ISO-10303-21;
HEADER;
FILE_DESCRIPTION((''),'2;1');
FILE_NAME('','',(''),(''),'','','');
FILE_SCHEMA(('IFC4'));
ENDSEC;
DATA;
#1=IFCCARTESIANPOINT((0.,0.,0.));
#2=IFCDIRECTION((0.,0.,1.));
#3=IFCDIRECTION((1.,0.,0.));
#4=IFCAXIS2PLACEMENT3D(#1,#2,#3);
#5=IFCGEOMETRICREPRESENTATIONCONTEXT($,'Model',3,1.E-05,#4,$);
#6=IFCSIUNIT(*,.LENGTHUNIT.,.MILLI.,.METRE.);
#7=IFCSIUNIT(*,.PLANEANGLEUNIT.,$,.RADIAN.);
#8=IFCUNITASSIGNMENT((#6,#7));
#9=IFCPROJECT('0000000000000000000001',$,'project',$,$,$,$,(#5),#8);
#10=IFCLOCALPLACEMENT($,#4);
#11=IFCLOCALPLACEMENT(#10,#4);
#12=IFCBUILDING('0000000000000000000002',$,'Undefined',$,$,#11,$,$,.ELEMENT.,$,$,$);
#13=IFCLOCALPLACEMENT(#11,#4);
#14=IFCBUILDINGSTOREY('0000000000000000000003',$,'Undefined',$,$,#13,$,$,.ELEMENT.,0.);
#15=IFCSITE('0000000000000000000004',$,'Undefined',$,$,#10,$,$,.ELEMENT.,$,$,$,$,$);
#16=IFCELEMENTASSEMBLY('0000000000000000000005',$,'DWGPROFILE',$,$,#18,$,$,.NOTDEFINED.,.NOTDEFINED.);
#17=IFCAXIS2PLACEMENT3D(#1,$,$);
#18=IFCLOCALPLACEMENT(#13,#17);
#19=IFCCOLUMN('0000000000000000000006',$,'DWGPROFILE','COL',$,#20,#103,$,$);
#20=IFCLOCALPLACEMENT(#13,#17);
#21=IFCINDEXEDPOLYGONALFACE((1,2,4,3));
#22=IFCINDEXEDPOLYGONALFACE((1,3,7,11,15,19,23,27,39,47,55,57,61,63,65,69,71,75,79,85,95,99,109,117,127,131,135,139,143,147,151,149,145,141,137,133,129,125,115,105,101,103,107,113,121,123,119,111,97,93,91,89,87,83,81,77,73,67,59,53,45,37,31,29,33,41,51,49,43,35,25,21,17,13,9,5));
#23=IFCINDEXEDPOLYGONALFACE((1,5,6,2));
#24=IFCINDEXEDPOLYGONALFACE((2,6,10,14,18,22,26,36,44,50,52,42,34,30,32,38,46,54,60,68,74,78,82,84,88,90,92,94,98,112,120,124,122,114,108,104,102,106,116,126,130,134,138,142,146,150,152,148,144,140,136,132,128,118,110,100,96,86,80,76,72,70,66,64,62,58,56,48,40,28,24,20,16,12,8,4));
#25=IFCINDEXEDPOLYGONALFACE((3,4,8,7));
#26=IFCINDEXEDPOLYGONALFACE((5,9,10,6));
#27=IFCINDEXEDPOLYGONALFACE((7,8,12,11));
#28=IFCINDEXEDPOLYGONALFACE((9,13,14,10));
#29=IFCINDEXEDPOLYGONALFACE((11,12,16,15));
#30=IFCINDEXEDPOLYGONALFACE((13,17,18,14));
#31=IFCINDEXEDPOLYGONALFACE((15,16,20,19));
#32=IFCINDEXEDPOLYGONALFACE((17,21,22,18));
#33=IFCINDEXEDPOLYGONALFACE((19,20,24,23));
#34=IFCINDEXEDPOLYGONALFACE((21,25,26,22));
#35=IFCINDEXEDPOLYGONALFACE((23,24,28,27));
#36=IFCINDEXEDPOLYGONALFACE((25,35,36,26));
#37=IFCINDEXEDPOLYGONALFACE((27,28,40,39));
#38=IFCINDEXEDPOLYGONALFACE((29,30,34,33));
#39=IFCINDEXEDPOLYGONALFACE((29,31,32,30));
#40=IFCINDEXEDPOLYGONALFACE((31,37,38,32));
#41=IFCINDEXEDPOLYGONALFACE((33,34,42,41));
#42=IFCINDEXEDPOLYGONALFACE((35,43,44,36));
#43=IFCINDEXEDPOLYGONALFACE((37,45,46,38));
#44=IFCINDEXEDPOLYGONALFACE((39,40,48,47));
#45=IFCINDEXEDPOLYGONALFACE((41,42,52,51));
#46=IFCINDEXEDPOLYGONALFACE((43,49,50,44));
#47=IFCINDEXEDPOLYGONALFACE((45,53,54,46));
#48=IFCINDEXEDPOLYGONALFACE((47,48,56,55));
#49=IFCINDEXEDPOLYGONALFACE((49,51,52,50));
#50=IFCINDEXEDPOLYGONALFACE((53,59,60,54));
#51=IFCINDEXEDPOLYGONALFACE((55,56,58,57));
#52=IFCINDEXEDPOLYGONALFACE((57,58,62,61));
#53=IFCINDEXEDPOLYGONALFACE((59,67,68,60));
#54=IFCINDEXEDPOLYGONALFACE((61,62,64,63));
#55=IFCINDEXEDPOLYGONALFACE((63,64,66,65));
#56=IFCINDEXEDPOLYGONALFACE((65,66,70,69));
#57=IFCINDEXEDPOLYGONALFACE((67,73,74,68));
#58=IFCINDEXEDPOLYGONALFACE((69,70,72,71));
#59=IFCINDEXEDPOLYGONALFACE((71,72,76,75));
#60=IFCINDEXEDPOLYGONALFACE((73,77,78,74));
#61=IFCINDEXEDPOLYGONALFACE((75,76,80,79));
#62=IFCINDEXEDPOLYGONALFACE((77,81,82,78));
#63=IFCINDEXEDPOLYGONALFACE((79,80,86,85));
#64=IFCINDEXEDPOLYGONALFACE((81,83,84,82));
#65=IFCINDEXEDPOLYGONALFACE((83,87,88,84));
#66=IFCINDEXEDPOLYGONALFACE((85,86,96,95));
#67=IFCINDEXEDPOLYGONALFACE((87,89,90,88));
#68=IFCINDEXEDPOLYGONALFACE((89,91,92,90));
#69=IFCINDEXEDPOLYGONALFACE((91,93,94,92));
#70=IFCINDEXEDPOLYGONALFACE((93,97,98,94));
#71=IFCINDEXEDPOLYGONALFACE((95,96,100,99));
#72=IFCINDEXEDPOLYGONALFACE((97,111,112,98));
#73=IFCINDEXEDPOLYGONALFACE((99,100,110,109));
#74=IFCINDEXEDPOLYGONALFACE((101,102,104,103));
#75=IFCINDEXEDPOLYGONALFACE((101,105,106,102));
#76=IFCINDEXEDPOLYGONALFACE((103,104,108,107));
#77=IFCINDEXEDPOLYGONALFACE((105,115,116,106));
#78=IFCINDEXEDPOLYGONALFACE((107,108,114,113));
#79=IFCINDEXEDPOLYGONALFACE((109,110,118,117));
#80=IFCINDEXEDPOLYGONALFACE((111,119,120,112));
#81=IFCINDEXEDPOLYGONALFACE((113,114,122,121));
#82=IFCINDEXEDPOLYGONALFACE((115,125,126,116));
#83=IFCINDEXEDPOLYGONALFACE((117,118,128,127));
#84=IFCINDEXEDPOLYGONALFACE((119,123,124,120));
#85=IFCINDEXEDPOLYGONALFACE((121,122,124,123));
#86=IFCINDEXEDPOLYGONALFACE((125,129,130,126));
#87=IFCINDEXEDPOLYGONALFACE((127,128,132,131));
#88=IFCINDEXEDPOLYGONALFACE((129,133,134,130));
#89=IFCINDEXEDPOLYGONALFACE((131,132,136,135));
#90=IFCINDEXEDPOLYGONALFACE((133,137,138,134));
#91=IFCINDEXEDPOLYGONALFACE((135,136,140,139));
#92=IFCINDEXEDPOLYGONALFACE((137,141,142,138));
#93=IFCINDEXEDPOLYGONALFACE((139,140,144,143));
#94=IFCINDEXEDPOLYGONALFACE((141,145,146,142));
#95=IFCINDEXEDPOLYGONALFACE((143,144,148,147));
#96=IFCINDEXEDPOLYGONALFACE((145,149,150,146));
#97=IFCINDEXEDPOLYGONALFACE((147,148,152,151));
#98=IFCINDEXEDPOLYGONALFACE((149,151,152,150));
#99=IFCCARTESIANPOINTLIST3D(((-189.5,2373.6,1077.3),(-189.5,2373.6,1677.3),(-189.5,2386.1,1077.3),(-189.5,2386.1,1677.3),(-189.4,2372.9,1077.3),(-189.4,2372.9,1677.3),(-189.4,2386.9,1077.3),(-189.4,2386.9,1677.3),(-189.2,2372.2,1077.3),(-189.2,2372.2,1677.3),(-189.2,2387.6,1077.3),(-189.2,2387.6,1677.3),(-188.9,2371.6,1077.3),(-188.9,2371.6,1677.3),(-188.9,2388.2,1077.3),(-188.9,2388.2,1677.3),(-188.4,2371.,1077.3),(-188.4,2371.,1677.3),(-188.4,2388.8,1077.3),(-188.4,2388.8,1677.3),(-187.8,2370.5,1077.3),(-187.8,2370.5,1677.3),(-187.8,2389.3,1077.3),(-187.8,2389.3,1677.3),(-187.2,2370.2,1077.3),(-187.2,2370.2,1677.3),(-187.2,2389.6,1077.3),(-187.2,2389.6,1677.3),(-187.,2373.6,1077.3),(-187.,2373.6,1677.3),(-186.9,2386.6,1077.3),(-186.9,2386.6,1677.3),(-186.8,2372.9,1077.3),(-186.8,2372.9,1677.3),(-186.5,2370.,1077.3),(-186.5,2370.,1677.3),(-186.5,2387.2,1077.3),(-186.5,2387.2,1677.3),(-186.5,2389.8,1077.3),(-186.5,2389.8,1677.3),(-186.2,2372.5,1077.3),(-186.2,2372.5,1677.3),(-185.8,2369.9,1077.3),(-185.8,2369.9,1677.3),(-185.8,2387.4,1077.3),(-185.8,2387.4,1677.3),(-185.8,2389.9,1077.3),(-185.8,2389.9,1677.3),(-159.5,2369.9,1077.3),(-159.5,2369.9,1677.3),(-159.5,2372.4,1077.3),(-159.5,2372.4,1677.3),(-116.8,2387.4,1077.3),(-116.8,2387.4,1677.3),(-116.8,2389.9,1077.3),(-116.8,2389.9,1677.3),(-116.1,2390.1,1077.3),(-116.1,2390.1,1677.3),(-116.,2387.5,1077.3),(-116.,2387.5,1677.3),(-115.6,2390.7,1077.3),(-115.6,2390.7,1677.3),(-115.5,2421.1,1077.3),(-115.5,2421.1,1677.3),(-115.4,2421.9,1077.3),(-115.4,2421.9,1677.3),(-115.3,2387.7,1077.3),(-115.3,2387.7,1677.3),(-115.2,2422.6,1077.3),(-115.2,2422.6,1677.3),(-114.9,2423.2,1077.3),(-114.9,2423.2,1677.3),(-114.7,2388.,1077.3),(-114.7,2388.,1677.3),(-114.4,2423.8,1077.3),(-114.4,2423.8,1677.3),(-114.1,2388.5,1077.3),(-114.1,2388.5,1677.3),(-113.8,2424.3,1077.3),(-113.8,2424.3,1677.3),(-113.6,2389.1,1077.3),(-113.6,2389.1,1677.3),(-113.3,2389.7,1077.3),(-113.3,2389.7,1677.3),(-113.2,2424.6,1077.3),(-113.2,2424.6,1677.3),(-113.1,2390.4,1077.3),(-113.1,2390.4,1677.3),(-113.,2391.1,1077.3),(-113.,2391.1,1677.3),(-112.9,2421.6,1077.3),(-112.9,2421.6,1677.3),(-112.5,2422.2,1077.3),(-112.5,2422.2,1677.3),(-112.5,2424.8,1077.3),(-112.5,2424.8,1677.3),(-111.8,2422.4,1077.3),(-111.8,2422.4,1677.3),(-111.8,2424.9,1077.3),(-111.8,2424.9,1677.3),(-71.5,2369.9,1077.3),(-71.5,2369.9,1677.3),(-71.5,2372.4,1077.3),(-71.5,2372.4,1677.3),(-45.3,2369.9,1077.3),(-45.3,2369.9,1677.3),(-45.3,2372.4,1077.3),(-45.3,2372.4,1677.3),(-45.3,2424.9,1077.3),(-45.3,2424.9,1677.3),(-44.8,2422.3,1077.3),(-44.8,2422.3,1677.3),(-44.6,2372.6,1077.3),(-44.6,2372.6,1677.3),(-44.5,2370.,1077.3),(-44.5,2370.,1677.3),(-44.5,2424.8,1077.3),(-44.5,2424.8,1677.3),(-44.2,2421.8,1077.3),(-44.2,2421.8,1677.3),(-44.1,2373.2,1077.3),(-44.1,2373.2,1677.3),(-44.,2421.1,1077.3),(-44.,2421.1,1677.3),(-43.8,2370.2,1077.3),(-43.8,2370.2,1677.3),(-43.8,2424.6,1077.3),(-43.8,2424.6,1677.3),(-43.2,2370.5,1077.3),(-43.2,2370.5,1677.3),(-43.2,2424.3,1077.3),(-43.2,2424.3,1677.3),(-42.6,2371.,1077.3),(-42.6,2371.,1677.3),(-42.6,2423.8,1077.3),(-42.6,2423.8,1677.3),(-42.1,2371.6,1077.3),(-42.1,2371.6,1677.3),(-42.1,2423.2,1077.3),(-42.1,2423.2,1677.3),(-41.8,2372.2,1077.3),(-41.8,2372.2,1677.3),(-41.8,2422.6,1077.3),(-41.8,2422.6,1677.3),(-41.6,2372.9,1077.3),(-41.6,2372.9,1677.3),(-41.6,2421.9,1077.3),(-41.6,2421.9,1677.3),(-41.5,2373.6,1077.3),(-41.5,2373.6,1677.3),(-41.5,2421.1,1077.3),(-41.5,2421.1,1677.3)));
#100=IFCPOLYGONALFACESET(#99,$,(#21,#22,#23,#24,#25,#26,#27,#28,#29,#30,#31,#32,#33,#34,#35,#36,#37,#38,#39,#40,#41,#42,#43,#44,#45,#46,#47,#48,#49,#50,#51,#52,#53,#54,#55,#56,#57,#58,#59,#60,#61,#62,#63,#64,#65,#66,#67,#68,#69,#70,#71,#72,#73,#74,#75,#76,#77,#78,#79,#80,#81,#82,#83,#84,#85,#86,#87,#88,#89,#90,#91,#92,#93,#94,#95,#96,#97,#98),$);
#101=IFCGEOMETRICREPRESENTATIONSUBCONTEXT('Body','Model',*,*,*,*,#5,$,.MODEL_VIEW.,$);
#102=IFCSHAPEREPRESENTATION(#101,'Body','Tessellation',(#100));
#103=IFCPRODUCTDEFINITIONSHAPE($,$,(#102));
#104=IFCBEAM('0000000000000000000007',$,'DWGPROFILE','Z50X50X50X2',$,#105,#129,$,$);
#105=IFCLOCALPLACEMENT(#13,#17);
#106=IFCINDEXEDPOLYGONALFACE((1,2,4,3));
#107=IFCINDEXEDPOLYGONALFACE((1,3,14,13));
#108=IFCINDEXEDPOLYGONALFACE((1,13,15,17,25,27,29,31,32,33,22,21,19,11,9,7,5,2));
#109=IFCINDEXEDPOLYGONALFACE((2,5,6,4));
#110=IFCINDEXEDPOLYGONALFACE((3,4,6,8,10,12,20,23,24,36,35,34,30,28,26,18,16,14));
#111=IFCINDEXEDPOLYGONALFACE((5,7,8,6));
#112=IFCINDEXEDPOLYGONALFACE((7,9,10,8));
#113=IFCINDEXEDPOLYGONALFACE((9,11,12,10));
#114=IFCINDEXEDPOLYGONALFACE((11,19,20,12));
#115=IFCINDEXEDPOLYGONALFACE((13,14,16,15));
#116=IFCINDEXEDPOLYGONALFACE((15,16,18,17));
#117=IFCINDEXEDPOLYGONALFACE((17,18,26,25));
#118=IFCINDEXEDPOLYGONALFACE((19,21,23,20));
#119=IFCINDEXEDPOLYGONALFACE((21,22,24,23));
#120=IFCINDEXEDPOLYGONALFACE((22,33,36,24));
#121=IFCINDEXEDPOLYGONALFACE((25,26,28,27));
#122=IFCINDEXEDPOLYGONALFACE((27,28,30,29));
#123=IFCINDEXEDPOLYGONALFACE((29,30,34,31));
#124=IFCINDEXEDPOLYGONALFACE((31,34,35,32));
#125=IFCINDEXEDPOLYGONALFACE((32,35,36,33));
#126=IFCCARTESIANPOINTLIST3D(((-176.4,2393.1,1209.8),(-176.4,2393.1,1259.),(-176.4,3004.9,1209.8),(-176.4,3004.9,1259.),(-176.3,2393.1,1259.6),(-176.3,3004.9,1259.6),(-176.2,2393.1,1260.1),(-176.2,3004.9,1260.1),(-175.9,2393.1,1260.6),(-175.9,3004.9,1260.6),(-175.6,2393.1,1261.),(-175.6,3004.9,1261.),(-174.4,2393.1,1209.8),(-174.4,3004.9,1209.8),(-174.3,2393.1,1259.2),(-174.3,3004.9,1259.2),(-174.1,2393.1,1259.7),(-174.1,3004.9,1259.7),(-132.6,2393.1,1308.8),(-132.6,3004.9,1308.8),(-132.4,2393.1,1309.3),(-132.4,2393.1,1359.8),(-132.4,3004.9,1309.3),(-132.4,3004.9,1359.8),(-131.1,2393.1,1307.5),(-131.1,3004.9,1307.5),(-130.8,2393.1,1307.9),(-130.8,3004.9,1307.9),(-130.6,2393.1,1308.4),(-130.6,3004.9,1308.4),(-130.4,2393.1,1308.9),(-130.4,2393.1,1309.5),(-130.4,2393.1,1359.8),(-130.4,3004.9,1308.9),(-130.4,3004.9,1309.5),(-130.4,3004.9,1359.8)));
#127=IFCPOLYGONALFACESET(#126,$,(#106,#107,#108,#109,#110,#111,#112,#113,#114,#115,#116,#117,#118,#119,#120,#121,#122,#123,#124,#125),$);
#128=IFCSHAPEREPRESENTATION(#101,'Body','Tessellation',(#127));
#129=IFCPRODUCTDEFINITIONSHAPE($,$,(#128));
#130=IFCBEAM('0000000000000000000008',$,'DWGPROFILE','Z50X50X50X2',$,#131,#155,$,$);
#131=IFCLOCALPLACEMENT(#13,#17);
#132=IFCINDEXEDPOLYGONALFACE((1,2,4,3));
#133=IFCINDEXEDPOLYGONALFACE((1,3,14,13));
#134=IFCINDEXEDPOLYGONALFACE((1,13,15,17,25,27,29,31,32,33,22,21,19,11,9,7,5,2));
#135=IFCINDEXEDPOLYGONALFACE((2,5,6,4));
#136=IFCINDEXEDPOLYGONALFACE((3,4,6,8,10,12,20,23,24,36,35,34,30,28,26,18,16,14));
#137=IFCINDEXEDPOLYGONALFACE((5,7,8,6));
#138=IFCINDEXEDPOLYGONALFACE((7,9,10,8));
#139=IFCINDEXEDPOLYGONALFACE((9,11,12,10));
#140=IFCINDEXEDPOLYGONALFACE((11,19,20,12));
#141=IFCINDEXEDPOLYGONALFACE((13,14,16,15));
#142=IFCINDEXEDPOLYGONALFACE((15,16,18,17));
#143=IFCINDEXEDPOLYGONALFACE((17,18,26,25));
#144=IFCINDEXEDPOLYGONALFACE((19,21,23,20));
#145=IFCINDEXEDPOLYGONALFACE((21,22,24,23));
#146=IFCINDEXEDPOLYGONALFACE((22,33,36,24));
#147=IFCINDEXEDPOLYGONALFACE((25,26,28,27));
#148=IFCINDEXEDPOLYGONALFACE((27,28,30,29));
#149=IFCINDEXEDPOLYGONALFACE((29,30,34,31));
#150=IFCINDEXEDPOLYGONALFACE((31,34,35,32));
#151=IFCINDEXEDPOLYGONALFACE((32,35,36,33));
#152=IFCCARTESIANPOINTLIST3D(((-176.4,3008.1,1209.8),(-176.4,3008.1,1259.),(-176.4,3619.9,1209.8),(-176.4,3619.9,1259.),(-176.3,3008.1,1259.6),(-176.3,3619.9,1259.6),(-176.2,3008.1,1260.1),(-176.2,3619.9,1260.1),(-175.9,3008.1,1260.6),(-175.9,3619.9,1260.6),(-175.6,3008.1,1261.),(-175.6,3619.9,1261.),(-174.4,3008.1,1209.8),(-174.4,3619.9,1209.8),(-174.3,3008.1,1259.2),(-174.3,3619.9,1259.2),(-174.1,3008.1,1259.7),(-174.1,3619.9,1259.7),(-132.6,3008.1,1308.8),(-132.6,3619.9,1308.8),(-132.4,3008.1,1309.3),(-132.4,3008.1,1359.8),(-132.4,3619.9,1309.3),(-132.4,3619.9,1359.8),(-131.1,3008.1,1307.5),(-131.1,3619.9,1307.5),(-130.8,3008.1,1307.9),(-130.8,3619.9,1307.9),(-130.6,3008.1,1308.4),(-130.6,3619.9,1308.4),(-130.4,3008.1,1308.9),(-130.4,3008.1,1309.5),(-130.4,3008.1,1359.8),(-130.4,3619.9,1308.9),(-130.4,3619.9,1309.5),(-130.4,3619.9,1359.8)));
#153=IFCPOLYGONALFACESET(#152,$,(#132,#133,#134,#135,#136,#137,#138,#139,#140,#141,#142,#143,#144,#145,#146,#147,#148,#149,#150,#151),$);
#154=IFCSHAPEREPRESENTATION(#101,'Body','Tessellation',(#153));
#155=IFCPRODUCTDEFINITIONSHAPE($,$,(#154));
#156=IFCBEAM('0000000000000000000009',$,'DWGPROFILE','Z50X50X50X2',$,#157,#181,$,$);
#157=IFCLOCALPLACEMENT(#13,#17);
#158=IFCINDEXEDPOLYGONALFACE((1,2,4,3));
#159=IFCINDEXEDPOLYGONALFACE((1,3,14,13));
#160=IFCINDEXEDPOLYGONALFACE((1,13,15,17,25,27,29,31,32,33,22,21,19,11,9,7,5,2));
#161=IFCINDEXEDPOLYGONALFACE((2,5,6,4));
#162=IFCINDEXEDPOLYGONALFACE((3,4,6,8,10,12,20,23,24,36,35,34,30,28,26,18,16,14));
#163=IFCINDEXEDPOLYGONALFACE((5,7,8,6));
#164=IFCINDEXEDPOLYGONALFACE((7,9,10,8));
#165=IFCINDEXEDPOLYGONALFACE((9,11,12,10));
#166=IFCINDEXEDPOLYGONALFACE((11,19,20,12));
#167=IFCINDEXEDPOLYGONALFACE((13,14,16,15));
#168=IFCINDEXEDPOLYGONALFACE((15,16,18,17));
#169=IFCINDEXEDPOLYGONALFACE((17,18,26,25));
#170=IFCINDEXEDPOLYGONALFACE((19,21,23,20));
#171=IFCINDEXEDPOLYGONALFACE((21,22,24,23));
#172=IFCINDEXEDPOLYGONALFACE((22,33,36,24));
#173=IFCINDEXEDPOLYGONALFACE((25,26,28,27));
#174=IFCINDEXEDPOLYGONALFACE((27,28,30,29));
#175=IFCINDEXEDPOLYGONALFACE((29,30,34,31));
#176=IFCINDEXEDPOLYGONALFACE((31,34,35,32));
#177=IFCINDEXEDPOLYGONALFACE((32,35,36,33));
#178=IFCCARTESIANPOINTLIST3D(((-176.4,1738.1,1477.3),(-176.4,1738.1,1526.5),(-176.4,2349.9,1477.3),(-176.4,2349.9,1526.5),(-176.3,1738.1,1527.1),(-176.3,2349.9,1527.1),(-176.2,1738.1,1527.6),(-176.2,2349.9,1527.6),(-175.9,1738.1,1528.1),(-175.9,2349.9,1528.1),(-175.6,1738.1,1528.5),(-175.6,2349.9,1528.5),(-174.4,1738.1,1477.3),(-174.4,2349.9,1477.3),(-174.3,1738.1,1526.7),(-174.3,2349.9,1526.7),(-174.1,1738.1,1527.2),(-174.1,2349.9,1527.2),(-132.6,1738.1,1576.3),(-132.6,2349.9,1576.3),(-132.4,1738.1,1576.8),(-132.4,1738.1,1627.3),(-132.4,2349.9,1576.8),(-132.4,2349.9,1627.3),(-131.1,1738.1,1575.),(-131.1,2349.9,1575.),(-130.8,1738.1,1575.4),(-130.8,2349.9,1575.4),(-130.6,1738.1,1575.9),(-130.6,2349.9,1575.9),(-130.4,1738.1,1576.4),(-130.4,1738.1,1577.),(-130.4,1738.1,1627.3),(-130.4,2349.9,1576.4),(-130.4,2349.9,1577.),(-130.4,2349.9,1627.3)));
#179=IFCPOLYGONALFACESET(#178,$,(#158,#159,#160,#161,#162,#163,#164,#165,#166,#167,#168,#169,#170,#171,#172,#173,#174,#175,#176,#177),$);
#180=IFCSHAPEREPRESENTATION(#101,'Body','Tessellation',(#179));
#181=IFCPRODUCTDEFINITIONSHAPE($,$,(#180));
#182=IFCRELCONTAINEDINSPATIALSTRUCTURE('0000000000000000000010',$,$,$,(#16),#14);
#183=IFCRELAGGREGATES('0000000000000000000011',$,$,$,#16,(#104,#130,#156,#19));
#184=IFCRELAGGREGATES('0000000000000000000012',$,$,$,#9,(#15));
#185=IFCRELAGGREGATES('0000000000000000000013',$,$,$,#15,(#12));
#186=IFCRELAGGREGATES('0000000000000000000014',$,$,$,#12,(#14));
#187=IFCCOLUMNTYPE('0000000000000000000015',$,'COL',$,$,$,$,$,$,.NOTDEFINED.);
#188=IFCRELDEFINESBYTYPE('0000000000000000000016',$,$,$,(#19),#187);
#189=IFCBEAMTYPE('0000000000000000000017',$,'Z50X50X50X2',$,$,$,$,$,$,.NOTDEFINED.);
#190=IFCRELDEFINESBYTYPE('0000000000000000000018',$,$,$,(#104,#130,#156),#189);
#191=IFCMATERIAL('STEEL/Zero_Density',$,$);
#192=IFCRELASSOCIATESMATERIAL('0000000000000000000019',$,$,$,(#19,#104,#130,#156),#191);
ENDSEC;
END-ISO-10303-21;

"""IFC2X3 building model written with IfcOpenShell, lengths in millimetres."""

from ifc_helpers import new_model, si_unit, frame, origin_with_axes, place, context, subcontext, project, spatial, polyline, outline, extrude, material, type_object, element, aggregate, save


model = new_model("IFC2X3")

# Units and contexts
model_context = context("Model", 3, precision=1e-05, world=origin_with_axes())
body_context = subcontext(model_context, "Body", "Model", "MODEL_VIEW")
ifc_project = project(units=[si_unit("LENGTHUNIT", "METRE", prefix="MILLI"), si_unit("PLANEANGLEUNIT", "RADIAN")], contexts=[model_context])

# Site, building, storey
site_placement = place(None, origin_with_axes())
site = spatial("IfcSite", under=ifc_project, at=site_placement, Name="Undefined", CompositionType="ELEMENT")
building_placement = place(site_placement, origin_with_axes())
building = spatial("IfcBuilding", under=site, at=building_placement, Name="Undefined", CompositionType="ELEMENT")
storey_placement = place(building_placement, origin_with_axes())
storey = spatial("IfcBuildingStorey", under=building, at=storey_placement, Name="Undefined", CompositionType="ELEMENT", Elevation=0.0)

# Element assembly, column, beams
assembly_1_placement = place(storey_placement, origin_with_axes())
assembly_1 = element("IfcElementAssembly", 1, at=assembly_1_placement, inside=storey, Name="DWGPROFILE", AssemblyPlace="NOTDEFINED", PredefinedType="NOTDEFINED")
ifc_material_1 = material(Name="STEEL/Zero_Density")
column_type = type_object("IfcColumnType", Name="COL", PredefinedType="NOTDEFINED")
column_placement = place(assembly_1_placement, frame((-115.5, 2397.4, 1077.3), z_axis=(0.0, 0.0, 1.0), x_axis=(1.0, 0.0, 0.0)))
column = element("IfcColumn", 2, at=column_placement, type_object=column_type, material=ifc_material_1, Name="DWGPROFILE", Description="COL", context=body_context, shape_type="SweptSolid", body=[
    extrude(outline(polyline([(27.5, 70.2), (27.5, 3.8), (27.4, 3.0), (27.2, 2.3), (26.9, 1.7), (26.4, 1.1), (25.8, 0.6), (25.2, 0.3), (24.5, 0.1), (23.8, 0.0), (-6.7, -0.1), (-7.3, -0.6), (-7.5, -1.2), (-7.5, -70.2), (-7.6, -71.0), (-7.8, -71.7), (-8.1, -72.3), (-8.6, -72.9), (-9.2, -73.4), (-9.8, -73.7), (-10.5, -73.9), (-11.2, -74.0), (-23.8, -74.0), (-24.5, -73.9), (-25.2, -73.7), (-25.8, -73.4), (-26.4, -72.9), (-26.9, -72.3), (-27.2, -71.7), (-27.4, -71.0), (-27.5, -70.2), (-27.5, -44.0), (-25.0, -44.0), (-24.9, -70.7), (-24.4, -71.3), (-23.8, -71.5), (-10.8, -71.4), (-10.2, -70.9), (-10.0, -70.2), (-10.0, -1.2), (-9.9, -0.5), (-9.7, 0.2), (-9.4, 0.8), (-8.9, 1.4), (-8.3, 1.9), (-7.7, 2.2), (-7.0, 2.4), (-6.2, 2.5), (24.2, 2.6), (24.8, 3.1), (25.0, 3.8), (24.9, 70.7), (24.4, 71.3), (23.8, 71.5), (-24.2, 71.4), (-24.8, 70.9), (-25.0, 70.2), (-25.0, 44.0), (-27.5, 44.0), (-27.5, 70.2), (-27.4, 71.0), (-27.2, 71.7), (-26.9, 72.3), (-26.4, 72.9), (-25.8, 73.4), (-25.2, 73.7), (-24.5, 73.9), (-23.8, 74.0), (23.8, 74.0), (24.5, 73.9), (25.2, 73.7), (25.8, 73.4), (26.4, 72.9), (26.9, 72.3), (27.2, 71.7), (27.4, 71.0), (27.5, 70.2)])), frame((0.0, 0.0, 600.0), z_axis=(0.0, 0.000001, -1.0), x_axis=(0.0, 1.0, 0.0)), (0.0, 0.0, 1.0), 600.0),
])
beam_type_1 = type_object("IfcBeamType", Name="Z50X50X50X2", PredefinedType="NOTDEFINED")
beam_1_placement = place(assembly_1_placement, frame((-153.4, 3004.9, 1284.8), z_axis=(0.0, 0.0, 1.0), x_axis=(0.0, -1.0, 0.0)))
beam_1 = element("IfcBeam", 3, at=beam_1_placement, type_object=beam_type_1, material=ifc_material_1, Name="DWGPROFILE", Description="Z50X50X50X2", context=body_context, shape_type="SweptSolid", body=[
    extrude(outline(polyline([(-22.9, 24.1), (-23.0, 24.7), (-23.0, 75.0), (-21.0, 75.0), (-21.0, 24.5), (-20.7, 24.0), (22.2, -23.8), (22.6, -24.2), (22.8, -24.7), (22.9, -25.2), (23.0, -25.8), (23.0, -75.0), (21.0, -75.0), (21.0, -25.6), (20.7, -25.1), (-22.2, 22.6), (-22.6, 23.1), (-22.8, 23.6), (-22.9, 24.1)])), frame((611.8, 0.0, 0.0), z_axis=(-1.0, 0.0, 0.0), x_axis=(0.0, -1.0, 0.0)), (0.0, 0.0, 1.0), 611.8),
])
beam_2_placement = place(assembly_1_placement, frame((-153.4, 3619.9, 1284.8), z_axis=(0.0, 0.0, 1.0), x_axis=(0.0, -1.0, 0.0)))
beam_2 = element("IfcBeam", 4, at=beam_2_placement, type_object=beam_type_1, material=ifc_material_1, Name="DWGPROFILE", Description="Z50X50X50X2", context=body_context, shape_type="SweptSolid", body=[
    extrude(outline(polyline([(-22.9, 24.1), (-23.0, 24.7), (-23.0, 75.0), (-21.0, 75.0), (-21.0, 24.5), (-20.7, 24.0), (22.2, -23.8), (22.6, -24.2), (22.8, -24.7), (22.9, -25.2), (23.0, -25.8), (23.0, -75.0), (21.0, -75.0), (21.0, -25.6), (20.7, -25.1), (-22.2, 22.6), (-22.6, 23.1), (-22.8, 23.6), (-22.9, 24.1)])), frame((611.8, 0.0, 0.0), z_axis=(-1.0, 0.0, 0.0), x_axis=(0.0, -1.0, 0.0)), (0.0, 0.0, 1.0), 611.8),
])
beam_3_placement = place(assembly_1_placement, frame((-153.4, 2349.9, 1552.3), z_axis=(0.0, 0.0, 1.0), x_axis=(0.0, -1.0, 0.0)))
beam_3 = element("IfcBeam", 5, at=beam_3_placement, type_object=beam_type_1, material=ifc_material_1, Name="DWGPROFILE", Description="Z50X50X50X2", context=body_context, shape_type="SweptSolid", body=[
    extrude(outline(polyline([(-22.9, 24.1), (-23.0, 24.7), (-23.0, 75.0), (-21.0, 75.0), (-21.0, 24.5), (-20.7, 24.0), (22.2, -23.8), (22.6, -24.2), (22.8, -24.7), (22.9, -25.2), (23.0, -25.8), (23.0, -75.0), (21.0, -75.0), (21.0, -25.6), (20.7, -25.1), (-22.2, 22.6), (-22.6, 23.1), (-22.8, 23.6), (-22.9, 24.1)])), frame((611.8, 0.0, 0.0), z_axis=(-1.0, 0.0, 0.0), x_axis=(0.0, -1.0, 0.0)), (0.0, 0.0, 1.0), 611.8),
])
aggregate(assembly_1, [beam_1, beam_2, beam_3, column])

save(model, "model.ifc")
